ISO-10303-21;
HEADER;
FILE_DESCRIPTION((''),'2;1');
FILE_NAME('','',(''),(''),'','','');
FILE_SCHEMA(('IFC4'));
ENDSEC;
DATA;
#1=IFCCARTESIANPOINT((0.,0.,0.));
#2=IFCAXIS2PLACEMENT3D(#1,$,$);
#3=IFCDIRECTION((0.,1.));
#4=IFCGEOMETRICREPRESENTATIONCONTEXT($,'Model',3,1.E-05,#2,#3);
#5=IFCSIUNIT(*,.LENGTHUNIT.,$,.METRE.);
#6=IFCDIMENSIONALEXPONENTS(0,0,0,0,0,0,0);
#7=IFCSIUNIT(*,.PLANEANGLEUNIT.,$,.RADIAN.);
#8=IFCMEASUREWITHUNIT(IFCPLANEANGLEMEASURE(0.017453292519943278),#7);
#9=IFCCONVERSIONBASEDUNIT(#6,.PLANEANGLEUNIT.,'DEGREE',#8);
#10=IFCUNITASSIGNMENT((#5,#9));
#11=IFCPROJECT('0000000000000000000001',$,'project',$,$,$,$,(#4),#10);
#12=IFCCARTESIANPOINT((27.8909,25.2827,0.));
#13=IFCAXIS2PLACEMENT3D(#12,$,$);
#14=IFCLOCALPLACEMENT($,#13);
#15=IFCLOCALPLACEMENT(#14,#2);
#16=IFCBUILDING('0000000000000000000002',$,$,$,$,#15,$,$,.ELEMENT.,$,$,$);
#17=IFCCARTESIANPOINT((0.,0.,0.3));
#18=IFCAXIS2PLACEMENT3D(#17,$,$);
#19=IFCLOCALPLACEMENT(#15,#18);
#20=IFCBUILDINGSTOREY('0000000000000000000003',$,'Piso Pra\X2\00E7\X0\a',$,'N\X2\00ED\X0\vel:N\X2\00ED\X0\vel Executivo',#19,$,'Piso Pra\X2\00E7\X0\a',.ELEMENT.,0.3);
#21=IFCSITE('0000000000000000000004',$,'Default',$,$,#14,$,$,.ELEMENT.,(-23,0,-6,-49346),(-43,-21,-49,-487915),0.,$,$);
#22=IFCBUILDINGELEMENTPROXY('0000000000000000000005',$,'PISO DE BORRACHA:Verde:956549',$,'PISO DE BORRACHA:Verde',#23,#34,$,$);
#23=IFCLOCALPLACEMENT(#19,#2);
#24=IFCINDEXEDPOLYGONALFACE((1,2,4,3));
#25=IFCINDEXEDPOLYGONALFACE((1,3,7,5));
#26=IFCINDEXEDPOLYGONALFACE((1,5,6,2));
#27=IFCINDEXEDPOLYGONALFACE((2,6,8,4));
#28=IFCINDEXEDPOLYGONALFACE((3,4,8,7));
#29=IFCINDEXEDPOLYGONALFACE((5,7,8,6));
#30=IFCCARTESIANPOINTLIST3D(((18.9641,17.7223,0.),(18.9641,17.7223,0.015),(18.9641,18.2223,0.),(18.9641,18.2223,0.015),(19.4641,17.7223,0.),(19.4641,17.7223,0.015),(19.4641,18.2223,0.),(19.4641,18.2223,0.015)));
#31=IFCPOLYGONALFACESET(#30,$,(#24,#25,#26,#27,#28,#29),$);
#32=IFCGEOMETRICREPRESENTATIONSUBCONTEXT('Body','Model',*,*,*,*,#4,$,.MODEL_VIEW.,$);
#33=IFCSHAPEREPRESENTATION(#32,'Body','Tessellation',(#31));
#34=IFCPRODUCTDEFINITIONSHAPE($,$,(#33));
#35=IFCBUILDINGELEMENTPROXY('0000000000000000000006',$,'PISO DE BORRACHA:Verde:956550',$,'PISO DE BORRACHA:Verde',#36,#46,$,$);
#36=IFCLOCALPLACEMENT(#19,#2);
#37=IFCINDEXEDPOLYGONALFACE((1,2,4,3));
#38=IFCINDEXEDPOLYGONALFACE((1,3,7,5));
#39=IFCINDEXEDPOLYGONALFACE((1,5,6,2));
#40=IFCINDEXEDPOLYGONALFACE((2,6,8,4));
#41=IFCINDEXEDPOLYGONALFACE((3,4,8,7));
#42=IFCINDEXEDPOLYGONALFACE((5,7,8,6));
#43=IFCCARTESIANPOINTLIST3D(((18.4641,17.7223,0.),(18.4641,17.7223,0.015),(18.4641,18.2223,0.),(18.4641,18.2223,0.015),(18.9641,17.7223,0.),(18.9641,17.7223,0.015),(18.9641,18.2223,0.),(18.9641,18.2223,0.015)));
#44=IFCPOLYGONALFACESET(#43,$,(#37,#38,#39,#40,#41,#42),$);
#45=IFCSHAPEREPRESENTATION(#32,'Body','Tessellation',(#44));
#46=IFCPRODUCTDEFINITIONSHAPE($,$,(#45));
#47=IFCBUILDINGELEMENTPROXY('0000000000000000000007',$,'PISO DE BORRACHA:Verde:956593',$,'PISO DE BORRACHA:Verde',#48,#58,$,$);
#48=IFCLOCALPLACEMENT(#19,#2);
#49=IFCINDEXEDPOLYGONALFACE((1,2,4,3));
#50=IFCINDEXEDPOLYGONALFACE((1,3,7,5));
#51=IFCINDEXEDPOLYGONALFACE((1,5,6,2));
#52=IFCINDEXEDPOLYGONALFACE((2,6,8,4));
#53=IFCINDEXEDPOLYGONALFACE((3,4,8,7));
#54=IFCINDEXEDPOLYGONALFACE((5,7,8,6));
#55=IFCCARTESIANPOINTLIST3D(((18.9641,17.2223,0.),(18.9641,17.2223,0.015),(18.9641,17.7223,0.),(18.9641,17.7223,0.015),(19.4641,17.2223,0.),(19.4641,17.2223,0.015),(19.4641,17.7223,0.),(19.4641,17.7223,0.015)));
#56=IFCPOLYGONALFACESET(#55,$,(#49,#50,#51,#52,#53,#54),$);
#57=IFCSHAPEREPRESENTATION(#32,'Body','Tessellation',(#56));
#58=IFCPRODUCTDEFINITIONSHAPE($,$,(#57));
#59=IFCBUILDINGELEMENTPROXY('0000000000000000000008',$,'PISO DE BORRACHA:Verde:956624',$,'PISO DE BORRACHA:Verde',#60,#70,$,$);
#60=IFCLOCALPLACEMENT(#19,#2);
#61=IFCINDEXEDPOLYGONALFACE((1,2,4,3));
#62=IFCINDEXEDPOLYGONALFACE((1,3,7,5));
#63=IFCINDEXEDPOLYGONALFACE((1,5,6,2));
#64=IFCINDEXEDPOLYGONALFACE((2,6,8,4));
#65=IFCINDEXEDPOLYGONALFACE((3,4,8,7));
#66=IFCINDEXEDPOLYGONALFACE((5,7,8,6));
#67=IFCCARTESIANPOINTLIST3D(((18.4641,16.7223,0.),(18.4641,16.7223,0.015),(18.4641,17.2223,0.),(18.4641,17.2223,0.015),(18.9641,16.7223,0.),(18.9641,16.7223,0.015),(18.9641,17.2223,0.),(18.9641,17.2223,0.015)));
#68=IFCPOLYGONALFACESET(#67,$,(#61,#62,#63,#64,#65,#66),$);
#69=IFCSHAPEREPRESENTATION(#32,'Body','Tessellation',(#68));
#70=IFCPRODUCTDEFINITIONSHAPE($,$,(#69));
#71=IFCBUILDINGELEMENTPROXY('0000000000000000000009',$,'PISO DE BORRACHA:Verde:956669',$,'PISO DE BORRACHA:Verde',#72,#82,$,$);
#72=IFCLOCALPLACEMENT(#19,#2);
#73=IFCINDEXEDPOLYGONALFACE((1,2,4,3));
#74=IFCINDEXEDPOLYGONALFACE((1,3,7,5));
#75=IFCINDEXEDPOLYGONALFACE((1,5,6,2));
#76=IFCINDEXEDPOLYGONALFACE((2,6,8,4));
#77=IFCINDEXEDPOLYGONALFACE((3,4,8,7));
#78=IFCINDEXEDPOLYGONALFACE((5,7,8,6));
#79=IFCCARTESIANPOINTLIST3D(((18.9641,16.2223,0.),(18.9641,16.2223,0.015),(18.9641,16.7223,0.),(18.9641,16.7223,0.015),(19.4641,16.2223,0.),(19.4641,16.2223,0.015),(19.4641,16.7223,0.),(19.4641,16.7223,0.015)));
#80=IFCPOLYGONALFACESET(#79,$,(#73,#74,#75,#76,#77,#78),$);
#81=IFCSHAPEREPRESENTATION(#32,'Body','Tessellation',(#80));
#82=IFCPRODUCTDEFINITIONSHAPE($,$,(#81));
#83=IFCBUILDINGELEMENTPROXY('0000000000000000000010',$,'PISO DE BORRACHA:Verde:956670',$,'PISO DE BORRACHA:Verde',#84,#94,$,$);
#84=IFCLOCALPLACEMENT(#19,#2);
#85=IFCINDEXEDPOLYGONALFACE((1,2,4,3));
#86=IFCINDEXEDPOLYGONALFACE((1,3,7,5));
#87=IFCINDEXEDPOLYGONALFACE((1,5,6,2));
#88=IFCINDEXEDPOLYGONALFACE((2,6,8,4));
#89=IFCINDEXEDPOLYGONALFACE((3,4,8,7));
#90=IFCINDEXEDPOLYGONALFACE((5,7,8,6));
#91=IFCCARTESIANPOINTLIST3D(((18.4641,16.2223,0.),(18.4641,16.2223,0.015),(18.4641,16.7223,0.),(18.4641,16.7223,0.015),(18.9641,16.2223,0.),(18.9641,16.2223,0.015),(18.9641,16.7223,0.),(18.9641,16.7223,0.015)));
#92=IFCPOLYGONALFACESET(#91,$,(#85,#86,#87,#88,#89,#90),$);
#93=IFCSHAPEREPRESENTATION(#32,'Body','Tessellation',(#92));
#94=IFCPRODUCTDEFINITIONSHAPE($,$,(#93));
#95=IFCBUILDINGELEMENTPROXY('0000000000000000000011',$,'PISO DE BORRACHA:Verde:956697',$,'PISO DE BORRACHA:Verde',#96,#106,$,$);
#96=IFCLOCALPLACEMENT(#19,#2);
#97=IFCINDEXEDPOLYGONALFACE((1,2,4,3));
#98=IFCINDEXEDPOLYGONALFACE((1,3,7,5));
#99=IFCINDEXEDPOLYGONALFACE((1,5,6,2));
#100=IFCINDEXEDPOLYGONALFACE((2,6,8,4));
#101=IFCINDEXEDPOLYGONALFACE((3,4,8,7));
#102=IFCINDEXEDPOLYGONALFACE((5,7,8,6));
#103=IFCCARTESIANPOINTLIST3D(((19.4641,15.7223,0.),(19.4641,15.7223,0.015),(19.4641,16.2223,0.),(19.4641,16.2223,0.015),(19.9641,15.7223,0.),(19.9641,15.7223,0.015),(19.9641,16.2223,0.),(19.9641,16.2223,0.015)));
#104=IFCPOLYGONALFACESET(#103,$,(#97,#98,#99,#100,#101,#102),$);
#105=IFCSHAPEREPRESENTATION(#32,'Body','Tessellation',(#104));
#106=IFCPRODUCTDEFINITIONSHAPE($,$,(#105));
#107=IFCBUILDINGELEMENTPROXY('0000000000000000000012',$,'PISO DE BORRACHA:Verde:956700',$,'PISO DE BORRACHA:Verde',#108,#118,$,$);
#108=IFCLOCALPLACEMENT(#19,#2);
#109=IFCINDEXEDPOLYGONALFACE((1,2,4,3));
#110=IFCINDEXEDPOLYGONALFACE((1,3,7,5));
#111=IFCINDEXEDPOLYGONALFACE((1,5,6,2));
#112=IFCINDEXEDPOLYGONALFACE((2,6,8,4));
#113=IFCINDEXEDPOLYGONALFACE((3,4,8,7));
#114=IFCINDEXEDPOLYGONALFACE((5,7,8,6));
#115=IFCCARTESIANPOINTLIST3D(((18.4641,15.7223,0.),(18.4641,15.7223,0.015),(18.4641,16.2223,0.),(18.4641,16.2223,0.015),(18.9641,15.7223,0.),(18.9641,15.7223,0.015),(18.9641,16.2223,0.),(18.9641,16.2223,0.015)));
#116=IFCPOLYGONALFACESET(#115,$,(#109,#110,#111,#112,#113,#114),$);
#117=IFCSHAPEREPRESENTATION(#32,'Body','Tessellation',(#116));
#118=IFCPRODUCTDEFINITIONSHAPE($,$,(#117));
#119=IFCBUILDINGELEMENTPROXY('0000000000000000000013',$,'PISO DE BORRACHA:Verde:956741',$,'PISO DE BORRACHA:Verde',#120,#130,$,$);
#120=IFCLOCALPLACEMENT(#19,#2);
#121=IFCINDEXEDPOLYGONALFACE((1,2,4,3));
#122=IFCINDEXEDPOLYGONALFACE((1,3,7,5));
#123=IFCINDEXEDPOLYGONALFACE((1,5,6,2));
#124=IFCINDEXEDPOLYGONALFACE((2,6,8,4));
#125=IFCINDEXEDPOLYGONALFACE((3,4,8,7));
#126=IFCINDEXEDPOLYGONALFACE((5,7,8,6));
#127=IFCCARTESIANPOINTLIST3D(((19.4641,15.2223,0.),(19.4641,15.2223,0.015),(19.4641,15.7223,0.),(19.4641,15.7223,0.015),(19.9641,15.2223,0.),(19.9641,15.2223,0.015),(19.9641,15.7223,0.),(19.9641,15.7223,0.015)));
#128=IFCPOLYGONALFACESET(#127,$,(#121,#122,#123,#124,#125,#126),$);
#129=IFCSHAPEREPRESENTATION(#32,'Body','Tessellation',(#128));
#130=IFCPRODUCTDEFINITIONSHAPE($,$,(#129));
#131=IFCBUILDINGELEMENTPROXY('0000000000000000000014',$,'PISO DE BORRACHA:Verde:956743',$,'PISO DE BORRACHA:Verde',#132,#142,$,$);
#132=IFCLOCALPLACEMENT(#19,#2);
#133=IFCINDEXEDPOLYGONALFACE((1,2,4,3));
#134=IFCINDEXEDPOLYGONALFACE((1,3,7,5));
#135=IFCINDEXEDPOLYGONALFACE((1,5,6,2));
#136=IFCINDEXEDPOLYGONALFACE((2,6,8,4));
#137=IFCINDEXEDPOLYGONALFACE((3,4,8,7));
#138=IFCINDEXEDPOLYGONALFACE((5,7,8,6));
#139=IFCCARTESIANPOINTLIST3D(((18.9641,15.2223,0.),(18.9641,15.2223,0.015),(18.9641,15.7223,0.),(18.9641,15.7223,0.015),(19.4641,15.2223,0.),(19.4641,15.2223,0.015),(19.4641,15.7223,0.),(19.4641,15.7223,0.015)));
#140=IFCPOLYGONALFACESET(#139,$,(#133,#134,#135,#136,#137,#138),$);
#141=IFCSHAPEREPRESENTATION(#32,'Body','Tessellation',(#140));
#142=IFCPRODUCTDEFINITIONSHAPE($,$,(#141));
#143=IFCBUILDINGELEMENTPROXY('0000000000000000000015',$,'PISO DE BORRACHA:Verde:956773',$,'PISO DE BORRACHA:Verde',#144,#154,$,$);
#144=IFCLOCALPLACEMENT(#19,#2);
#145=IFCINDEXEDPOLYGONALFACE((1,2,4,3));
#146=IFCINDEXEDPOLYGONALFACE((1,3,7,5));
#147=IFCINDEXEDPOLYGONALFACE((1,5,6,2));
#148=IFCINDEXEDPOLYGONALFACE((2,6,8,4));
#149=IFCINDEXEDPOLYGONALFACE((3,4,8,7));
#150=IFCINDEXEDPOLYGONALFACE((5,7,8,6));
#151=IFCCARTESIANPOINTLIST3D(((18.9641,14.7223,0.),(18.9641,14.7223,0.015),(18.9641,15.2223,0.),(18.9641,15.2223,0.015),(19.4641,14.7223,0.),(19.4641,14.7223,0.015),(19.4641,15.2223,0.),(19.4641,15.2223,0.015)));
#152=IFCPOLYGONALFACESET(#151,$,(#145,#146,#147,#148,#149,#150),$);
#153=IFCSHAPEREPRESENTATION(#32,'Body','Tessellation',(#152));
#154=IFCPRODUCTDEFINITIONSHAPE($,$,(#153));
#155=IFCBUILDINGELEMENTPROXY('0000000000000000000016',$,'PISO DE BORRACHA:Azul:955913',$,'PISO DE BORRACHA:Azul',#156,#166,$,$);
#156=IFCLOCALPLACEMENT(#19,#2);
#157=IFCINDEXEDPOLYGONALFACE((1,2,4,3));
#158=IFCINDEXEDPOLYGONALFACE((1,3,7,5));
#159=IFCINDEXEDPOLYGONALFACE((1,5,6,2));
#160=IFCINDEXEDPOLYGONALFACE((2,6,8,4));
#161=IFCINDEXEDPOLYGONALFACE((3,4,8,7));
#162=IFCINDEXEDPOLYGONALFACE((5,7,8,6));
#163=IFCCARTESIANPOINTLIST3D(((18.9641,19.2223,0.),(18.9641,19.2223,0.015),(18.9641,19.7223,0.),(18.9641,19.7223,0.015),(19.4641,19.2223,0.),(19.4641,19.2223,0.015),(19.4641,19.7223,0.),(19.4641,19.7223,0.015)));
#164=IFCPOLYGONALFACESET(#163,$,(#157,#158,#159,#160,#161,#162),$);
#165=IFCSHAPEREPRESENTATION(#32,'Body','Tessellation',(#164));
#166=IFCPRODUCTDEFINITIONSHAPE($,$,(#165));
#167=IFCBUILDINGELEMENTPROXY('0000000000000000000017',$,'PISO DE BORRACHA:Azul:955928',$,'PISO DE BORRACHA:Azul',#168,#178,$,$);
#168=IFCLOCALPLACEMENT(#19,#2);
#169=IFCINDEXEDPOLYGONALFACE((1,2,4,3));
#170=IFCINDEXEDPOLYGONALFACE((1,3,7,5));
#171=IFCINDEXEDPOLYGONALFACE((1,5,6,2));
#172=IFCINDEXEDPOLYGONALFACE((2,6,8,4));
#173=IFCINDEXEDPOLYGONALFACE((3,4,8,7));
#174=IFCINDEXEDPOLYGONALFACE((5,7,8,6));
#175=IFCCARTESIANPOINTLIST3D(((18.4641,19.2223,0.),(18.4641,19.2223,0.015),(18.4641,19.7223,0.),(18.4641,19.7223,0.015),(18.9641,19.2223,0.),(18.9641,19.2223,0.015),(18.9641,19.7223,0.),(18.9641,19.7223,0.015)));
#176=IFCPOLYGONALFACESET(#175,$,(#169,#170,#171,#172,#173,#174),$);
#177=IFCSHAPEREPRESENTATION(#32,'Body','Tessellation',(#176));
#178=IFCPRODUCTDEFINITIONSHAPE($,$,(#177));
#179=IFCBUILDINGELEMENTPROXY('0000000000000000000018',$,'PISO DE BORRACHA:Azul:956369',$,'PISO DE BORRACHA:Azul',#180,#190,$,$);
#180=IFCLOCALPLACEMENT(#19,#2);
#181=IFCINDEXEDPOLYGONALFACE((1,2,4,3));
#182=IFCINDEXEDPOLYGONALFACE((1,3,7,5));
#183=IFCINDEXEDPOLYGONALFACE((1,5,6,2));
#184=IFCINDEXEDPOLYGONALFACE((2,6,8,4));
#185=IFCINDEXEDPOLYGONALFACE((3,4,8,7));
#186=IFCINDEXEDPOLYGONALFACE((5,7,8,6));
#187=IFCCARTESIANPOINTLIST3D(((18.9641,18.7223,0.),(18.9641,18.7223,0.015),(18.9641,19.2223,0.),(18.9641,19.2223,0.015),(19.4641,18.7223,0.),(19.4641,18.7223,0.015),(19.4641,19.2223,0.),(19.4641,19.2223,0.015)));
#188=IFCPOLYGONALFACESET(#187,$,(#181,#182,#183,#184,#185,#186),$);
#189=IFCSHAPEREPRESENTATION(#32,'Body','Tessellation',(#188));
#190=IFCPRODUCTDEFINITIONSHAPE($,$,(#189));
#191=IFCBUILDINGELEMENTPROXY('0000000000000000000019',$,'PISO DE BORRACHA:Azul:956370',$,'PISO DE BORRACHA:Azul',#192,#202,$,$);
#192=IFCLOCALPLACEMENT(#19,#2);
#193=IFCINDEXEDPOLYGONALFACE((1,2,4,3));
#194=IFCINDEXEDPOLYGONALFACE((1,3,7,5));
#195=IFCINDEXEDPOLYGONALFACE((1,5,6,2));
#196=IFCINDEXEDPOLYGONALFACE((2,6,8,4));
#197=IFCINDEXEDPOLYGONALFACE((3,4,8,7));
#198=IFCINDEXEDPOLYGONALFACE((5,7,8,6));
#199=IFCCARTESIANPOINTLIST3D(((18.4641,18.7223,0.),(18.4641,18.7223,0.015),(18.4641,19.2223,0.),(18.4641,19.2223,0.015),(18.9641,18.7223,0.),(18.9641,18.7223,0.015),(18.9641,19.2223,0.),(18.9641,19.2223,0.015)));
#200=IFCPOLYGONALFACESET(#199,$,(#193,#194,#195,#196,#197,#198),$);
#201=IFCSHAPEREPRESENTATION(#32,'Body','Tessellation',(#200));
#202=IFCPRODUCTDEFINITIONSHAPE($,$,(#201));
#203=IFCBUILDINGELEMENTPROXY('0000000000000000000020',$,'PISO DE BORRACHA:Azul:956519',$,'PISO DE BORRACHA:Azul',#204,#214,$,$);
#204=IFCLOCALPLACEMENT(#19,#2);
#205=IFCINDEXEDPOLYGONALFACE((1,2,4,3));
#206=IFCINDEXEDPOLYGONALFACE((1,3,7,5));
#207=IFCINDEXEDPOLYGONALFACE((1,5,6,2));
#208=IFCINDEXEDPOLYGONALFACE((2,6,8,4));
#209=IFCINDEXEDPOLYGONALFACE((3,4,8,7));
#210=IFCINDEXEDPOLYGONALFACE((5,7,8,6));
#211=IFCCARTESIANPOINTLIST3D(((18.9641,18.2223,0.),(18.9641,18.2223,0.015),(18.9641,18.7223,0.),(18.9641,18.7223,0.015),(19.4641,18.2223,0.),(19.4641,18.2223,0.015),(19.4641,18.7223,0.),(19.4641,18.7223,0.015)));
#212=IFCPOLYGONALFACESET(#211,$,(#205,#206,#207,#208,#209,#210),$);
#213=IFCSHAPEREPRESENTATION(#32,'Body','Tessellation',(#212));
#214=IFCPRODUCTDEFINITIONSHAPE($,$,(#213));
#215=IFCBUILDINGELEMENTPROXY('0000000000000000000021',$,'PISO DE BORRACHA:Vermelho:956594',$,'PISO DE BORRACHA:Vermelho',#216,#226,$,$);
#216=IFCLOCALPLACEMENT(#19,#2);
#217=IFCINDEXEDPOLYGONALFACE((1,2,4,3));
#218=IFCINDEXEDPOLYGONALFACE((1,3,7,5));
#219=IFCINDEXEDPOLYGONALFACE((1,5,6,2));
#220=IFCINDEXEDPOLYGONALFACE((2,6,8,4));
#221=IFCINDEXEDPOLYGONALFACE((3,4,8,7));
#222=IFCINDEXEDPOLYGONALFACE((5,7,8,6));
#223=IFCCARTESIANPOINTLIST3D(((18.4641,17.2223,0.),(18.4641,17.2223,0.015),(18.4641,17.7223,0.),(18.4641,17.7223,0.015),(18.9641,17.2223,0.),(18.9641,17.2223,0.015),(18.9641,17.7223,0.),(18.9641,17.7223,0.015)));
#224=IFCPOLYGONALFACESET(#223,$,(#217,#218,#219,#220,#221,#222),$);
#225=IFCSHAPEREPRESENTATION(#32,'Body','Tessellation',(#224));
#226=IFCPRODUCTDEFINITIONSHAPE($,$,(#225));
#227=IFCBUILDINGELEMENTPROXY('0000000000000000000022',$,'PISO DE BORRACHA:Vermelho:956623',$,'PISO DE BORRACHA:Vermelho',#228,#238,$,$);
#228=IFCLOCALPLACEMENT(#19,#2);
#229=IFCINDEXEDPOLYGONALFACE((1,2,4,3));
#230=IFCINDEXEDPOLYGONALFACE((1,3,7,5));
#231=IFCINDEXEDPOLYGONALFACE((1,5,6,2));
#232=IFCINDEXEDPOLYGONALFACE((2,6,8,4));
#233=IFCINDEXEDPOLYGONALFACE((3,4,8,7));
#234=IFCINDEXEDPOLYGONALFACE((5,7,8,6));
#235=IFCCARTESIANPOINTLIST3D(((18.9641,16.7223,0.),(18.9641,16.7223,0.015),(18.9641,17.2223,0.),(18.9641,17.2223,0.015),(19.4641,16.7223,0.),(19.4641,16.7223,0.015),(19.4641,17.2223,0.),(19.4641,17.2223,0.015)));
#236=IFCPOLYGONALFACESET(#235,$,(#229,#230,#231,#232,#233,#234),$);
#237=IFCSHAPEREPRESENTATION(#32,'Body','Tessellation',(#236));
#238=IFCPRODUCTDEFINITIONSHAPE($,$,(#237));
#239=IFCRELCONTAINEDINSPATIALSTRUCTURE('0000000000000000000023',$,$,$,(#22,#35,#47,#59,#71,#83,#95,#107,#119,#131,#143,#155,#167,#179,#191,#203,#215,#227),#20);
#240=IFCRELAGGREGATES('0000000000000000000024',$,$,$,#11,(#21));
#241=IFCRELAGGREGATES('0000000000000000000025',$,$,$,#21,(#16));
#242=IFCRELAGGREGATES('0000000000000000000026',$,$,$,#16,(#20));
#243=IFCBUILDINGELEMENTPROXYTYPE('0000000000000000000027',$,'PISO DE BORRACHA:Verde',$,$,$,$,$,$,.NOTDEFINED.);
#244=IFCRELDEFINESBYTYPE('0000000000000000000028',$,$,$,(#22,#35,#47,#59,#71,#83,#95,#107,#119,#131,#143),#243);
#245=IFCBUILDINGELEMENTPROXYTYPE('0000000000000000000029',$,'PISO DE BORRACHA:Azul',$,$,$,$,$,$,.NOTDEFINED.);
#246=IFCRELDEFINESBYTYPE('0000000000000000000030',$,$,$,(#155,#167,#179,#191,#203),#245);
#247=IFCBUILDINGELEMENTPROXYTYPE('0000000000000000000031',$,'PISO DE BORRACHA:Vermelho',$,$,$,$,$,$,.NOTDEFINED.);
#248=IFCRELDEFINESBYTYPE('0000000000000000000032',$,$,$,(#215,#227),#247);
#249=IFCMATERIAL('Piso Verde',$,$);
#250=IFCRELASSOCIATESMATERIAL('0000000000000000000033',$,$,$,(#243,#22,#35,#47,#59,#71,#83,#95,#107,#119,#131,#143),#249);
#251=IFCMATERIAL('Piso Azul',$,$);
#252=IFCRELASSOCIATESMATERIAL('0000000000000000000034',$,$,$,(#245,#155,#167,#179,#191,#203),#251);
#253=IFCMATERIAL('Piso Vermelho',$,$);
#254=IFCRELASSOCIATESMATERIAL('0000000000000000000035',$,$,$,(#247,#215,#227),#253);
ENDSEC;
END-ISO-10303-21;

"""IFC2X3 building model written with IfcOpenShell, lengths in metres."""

from ifc_helpers import new_model, entity, si_unit, converted_unit, direction, frame, origin, origin_2d_with_axis, place, context, subcontext, project, spatial, rectangle, extrude, source, transform, mapped, material, type_object, type_shapes, element, save


model = new_model("IFC2X3")

# Units and contexts
model_context = context("Model", 3, precision=1e-05, world=origin(), true_north=direction((0.0, 1.0)))
body_context = subcontext(model_context, "Body", "Model", "MODEL_VIEW")
ifc_project = project(units=[si_unit("LENGTHUNIT", "METRE"), converted_unit("PLANEANGLEUNIT", "DEGREE", entity("IfcPlaneAngleMeasure", 0.017453292519943278), si_unit("PLANEANGLEUNIT", "RADIAN"), dimensions=[0, 0, 0, 0, 0, 0, 0])], contexts=[model_context])

# Site, building, storey
site_placement = place(None, frame((27.8909, 25.2827, 0.0)))
site = spatial("IfcSite", under=ifc_project, at=site_placement, Name="Default", CompositionType="ELEMENT", RefLatitude=(-23, 0, -6, -49346), RefLongitude=(-43, -21, -49, -487915), RefElevation=0.0)
building_placement = place(site_placement, origin())
building = spatial("IfcBuilding", under=site, at=building_placement, CompositionType="ELEMENT")
storey_placement = place(building_placement, frame((0.0, 0.0, 0.3)))
storey = spatial("IfcBuildingStorey", under=building, at=storey_placement, Name="Piso Praça", ObjectType="Nível:Nível Executivo", LongName="Piso Praça", CompositionType="ELEMENT", Elevation=0.3)

# Building element proxies
ifc_material_1 = material(Name="Piso Verde")
building_element_proxy_type_1 = type_object("IfcBuildingElementProxyType", Name="PISO DE BORRACHA:Verde", PredefinedType="NOTDEFINED", material=ifc_material_1)
shared_shape_1 = source(origin(), body_context, "Body", "SweptSolid", [
    extrude(rectangle(XDim=0.5, YDim=0.5, at=origin_2d_with_axis()), frame((0.25, 0.25, 0.0), z_axis=(0.0, 0.0, 1.0), x_axis=(-1.0, 0.0, 0.0)), (0.0, 0.0, 1.0), 0.015),
])
type_shapes(building_element_proxy_type_1, [shared_shape_1])
for number, where, name in (
    (1, (18.9641, 17.7223, 0.0), "PISO DE BORRACHA:Verde:956549"),
    (2, (18.4641, 17.7223, 0.0), "PISO DE BORRACHA:Verde:956550"),
    (3, (18.9641, 17.2223, 0.0), "PISO DE BORRACHA:Verde:956593"),
    (4, (18.4641, 16.7223, 0.0), "PISO DE BORRACHA:Verde:956624"),
    (5, (18.9641, 16.2223, 0.0), "PISO DE BORRACHA:Verde:956669"),
    (6, (18.4641, 16.2223, 0.0), "PISO DE BORRACHA:Verde:956670"),
    (7, (19.4641, 15.7223, 0.0), "PISO DE BORRACHA:Verde:956697"),
    (8, (18.4641, 15.7223, 0.0), "PISO DE BORRACHA:Verde:956700"),
    (9, (19.4641, 15.2223, 0.0), "PISO DE BORRACHA:Verde:956741"),
    (10, (18.9641, 15.2223, 0.0), "PISO DE BORRACHA:Verde:956743"),
    (11, (18.9641, 14.7223, 0.0), "PISO DE BORRACHA:Verde:956773"),
):
    element("IfcBuildingElementProxy", number, at=place(storey_placement, frame(where)), inside=storey, type_object=building_element_proxy_type_1, material=ifc_material_1, Name=name, ObjectType="PISO DE BORRACHA:Verde", context=body_context, shape_type="MappedRepresentation", body=[
        mapped(shared_shape_1, transform((0.0, 0.0, 0.0), scale=1.0)),
    ])
ifc_material_2 = material(Name="Piso Azul")
building_element_proxy_type_2 = type_object("IfcBuildingElementProxyType", Name="PISO DE BORRACHA:Azul", PredefinedType="NOTDEFINED", material=ifc_material_2)
shared_shape_2 = source(origin(), body_context, "Body", "SweptSolid", [
    extrude(rectangle(XDim=0.5, YDim=0.5, at=origin_2d_with_axis()), frame((0.25, 0.25, 0.0), z_axis=(0.0, 0.0, 1.0), x_axis=(-1.0, 0.0, 0.0)), (0.0, 0.0, 1.0), 0.015),
])
type_shapes(building_element_proxy_type_2, [shared_shape_2])
for number, where, name in (
    (12, (18.9641, 19.2223, 0.0), "PISO DE BORRACHA:Azul:955913"),
    (13, (18.4641, 19.2223, 0.0), "PISO DE BORRACHA:Azul:955928"),
    (14, (18.9641, 18.7223, 0.0), "PISO DE BORRACHA:Azul:956369"),
    (15, (18.4641, 18.7223, 0.0), "PISO DE BORRACHA:Azul:956370"),
    (16, (18.9641, 18.2223, 0.0), "PISO DE BORRACHA:Azul:956519"),
):
    element("IfcBuildingElementProxy", number, at=place(storey_placement, frame(where)), inside=storey, type_object=building_element_proxy_type_2, material=ifc_material_2, Name=name, ObjectType="PISO DE BORRACHA:Azul", context=body_context, shape_type="MappedRepresentation", body=[
        mapped(shared_shape_2, transform((0.0, 0.0, 0.0), scale=1.0)),
    ])
ifc_material_3 = material(Name="Piso Vermelho")
building_element_proxy_type_3 = type_object("IfcBuildingElementProxyType", Name="PISO DE BORRACHA:Vermelho", PredefinedType="NOTDEFINED", material=ifc_material_3)
shared_shape_3 = source(origin(), body_context, "Body", "SweptSolid", [
    extrude(rectangle(XDim=0.5, YDim=0.5, at=origin_2d_with_axis()), frame((0.25, 0.25, 0.0), z_axis=(0.0, 0.0, 1.0), x_axis=(-1.0, 0.0, 0.0)), (0.0, 0.0, 1.0), 0.015),
])
type_shapes(building_element_proxy_type_3, [shared_shape_3])
for number, where, name in (
    (17, (18.4641, 17.2223, 0.0), "PISO DE BORRACHA:Vermelho:956594"),
    (18, (18.9641, 16.7223, 0.0), "PISO DE BORRACHA:Vermelho:956623"),
):
    element("IfcBuildingElementProxy", number, at=place(storey_placement, frame(where)), inside=storey, type_object=building_element_proxy_type_3, material=ifc_material_3, Name=name, ObjectType="PISO DE BORRACHA:Vermelho", context=body_context, shape_type="MappedRepresentation", body=[
        mapped(shared_shape_3, transform((0.0, 0.0, 0.0), scale=1.0)),
    ])

save(model, "model.ifc")
